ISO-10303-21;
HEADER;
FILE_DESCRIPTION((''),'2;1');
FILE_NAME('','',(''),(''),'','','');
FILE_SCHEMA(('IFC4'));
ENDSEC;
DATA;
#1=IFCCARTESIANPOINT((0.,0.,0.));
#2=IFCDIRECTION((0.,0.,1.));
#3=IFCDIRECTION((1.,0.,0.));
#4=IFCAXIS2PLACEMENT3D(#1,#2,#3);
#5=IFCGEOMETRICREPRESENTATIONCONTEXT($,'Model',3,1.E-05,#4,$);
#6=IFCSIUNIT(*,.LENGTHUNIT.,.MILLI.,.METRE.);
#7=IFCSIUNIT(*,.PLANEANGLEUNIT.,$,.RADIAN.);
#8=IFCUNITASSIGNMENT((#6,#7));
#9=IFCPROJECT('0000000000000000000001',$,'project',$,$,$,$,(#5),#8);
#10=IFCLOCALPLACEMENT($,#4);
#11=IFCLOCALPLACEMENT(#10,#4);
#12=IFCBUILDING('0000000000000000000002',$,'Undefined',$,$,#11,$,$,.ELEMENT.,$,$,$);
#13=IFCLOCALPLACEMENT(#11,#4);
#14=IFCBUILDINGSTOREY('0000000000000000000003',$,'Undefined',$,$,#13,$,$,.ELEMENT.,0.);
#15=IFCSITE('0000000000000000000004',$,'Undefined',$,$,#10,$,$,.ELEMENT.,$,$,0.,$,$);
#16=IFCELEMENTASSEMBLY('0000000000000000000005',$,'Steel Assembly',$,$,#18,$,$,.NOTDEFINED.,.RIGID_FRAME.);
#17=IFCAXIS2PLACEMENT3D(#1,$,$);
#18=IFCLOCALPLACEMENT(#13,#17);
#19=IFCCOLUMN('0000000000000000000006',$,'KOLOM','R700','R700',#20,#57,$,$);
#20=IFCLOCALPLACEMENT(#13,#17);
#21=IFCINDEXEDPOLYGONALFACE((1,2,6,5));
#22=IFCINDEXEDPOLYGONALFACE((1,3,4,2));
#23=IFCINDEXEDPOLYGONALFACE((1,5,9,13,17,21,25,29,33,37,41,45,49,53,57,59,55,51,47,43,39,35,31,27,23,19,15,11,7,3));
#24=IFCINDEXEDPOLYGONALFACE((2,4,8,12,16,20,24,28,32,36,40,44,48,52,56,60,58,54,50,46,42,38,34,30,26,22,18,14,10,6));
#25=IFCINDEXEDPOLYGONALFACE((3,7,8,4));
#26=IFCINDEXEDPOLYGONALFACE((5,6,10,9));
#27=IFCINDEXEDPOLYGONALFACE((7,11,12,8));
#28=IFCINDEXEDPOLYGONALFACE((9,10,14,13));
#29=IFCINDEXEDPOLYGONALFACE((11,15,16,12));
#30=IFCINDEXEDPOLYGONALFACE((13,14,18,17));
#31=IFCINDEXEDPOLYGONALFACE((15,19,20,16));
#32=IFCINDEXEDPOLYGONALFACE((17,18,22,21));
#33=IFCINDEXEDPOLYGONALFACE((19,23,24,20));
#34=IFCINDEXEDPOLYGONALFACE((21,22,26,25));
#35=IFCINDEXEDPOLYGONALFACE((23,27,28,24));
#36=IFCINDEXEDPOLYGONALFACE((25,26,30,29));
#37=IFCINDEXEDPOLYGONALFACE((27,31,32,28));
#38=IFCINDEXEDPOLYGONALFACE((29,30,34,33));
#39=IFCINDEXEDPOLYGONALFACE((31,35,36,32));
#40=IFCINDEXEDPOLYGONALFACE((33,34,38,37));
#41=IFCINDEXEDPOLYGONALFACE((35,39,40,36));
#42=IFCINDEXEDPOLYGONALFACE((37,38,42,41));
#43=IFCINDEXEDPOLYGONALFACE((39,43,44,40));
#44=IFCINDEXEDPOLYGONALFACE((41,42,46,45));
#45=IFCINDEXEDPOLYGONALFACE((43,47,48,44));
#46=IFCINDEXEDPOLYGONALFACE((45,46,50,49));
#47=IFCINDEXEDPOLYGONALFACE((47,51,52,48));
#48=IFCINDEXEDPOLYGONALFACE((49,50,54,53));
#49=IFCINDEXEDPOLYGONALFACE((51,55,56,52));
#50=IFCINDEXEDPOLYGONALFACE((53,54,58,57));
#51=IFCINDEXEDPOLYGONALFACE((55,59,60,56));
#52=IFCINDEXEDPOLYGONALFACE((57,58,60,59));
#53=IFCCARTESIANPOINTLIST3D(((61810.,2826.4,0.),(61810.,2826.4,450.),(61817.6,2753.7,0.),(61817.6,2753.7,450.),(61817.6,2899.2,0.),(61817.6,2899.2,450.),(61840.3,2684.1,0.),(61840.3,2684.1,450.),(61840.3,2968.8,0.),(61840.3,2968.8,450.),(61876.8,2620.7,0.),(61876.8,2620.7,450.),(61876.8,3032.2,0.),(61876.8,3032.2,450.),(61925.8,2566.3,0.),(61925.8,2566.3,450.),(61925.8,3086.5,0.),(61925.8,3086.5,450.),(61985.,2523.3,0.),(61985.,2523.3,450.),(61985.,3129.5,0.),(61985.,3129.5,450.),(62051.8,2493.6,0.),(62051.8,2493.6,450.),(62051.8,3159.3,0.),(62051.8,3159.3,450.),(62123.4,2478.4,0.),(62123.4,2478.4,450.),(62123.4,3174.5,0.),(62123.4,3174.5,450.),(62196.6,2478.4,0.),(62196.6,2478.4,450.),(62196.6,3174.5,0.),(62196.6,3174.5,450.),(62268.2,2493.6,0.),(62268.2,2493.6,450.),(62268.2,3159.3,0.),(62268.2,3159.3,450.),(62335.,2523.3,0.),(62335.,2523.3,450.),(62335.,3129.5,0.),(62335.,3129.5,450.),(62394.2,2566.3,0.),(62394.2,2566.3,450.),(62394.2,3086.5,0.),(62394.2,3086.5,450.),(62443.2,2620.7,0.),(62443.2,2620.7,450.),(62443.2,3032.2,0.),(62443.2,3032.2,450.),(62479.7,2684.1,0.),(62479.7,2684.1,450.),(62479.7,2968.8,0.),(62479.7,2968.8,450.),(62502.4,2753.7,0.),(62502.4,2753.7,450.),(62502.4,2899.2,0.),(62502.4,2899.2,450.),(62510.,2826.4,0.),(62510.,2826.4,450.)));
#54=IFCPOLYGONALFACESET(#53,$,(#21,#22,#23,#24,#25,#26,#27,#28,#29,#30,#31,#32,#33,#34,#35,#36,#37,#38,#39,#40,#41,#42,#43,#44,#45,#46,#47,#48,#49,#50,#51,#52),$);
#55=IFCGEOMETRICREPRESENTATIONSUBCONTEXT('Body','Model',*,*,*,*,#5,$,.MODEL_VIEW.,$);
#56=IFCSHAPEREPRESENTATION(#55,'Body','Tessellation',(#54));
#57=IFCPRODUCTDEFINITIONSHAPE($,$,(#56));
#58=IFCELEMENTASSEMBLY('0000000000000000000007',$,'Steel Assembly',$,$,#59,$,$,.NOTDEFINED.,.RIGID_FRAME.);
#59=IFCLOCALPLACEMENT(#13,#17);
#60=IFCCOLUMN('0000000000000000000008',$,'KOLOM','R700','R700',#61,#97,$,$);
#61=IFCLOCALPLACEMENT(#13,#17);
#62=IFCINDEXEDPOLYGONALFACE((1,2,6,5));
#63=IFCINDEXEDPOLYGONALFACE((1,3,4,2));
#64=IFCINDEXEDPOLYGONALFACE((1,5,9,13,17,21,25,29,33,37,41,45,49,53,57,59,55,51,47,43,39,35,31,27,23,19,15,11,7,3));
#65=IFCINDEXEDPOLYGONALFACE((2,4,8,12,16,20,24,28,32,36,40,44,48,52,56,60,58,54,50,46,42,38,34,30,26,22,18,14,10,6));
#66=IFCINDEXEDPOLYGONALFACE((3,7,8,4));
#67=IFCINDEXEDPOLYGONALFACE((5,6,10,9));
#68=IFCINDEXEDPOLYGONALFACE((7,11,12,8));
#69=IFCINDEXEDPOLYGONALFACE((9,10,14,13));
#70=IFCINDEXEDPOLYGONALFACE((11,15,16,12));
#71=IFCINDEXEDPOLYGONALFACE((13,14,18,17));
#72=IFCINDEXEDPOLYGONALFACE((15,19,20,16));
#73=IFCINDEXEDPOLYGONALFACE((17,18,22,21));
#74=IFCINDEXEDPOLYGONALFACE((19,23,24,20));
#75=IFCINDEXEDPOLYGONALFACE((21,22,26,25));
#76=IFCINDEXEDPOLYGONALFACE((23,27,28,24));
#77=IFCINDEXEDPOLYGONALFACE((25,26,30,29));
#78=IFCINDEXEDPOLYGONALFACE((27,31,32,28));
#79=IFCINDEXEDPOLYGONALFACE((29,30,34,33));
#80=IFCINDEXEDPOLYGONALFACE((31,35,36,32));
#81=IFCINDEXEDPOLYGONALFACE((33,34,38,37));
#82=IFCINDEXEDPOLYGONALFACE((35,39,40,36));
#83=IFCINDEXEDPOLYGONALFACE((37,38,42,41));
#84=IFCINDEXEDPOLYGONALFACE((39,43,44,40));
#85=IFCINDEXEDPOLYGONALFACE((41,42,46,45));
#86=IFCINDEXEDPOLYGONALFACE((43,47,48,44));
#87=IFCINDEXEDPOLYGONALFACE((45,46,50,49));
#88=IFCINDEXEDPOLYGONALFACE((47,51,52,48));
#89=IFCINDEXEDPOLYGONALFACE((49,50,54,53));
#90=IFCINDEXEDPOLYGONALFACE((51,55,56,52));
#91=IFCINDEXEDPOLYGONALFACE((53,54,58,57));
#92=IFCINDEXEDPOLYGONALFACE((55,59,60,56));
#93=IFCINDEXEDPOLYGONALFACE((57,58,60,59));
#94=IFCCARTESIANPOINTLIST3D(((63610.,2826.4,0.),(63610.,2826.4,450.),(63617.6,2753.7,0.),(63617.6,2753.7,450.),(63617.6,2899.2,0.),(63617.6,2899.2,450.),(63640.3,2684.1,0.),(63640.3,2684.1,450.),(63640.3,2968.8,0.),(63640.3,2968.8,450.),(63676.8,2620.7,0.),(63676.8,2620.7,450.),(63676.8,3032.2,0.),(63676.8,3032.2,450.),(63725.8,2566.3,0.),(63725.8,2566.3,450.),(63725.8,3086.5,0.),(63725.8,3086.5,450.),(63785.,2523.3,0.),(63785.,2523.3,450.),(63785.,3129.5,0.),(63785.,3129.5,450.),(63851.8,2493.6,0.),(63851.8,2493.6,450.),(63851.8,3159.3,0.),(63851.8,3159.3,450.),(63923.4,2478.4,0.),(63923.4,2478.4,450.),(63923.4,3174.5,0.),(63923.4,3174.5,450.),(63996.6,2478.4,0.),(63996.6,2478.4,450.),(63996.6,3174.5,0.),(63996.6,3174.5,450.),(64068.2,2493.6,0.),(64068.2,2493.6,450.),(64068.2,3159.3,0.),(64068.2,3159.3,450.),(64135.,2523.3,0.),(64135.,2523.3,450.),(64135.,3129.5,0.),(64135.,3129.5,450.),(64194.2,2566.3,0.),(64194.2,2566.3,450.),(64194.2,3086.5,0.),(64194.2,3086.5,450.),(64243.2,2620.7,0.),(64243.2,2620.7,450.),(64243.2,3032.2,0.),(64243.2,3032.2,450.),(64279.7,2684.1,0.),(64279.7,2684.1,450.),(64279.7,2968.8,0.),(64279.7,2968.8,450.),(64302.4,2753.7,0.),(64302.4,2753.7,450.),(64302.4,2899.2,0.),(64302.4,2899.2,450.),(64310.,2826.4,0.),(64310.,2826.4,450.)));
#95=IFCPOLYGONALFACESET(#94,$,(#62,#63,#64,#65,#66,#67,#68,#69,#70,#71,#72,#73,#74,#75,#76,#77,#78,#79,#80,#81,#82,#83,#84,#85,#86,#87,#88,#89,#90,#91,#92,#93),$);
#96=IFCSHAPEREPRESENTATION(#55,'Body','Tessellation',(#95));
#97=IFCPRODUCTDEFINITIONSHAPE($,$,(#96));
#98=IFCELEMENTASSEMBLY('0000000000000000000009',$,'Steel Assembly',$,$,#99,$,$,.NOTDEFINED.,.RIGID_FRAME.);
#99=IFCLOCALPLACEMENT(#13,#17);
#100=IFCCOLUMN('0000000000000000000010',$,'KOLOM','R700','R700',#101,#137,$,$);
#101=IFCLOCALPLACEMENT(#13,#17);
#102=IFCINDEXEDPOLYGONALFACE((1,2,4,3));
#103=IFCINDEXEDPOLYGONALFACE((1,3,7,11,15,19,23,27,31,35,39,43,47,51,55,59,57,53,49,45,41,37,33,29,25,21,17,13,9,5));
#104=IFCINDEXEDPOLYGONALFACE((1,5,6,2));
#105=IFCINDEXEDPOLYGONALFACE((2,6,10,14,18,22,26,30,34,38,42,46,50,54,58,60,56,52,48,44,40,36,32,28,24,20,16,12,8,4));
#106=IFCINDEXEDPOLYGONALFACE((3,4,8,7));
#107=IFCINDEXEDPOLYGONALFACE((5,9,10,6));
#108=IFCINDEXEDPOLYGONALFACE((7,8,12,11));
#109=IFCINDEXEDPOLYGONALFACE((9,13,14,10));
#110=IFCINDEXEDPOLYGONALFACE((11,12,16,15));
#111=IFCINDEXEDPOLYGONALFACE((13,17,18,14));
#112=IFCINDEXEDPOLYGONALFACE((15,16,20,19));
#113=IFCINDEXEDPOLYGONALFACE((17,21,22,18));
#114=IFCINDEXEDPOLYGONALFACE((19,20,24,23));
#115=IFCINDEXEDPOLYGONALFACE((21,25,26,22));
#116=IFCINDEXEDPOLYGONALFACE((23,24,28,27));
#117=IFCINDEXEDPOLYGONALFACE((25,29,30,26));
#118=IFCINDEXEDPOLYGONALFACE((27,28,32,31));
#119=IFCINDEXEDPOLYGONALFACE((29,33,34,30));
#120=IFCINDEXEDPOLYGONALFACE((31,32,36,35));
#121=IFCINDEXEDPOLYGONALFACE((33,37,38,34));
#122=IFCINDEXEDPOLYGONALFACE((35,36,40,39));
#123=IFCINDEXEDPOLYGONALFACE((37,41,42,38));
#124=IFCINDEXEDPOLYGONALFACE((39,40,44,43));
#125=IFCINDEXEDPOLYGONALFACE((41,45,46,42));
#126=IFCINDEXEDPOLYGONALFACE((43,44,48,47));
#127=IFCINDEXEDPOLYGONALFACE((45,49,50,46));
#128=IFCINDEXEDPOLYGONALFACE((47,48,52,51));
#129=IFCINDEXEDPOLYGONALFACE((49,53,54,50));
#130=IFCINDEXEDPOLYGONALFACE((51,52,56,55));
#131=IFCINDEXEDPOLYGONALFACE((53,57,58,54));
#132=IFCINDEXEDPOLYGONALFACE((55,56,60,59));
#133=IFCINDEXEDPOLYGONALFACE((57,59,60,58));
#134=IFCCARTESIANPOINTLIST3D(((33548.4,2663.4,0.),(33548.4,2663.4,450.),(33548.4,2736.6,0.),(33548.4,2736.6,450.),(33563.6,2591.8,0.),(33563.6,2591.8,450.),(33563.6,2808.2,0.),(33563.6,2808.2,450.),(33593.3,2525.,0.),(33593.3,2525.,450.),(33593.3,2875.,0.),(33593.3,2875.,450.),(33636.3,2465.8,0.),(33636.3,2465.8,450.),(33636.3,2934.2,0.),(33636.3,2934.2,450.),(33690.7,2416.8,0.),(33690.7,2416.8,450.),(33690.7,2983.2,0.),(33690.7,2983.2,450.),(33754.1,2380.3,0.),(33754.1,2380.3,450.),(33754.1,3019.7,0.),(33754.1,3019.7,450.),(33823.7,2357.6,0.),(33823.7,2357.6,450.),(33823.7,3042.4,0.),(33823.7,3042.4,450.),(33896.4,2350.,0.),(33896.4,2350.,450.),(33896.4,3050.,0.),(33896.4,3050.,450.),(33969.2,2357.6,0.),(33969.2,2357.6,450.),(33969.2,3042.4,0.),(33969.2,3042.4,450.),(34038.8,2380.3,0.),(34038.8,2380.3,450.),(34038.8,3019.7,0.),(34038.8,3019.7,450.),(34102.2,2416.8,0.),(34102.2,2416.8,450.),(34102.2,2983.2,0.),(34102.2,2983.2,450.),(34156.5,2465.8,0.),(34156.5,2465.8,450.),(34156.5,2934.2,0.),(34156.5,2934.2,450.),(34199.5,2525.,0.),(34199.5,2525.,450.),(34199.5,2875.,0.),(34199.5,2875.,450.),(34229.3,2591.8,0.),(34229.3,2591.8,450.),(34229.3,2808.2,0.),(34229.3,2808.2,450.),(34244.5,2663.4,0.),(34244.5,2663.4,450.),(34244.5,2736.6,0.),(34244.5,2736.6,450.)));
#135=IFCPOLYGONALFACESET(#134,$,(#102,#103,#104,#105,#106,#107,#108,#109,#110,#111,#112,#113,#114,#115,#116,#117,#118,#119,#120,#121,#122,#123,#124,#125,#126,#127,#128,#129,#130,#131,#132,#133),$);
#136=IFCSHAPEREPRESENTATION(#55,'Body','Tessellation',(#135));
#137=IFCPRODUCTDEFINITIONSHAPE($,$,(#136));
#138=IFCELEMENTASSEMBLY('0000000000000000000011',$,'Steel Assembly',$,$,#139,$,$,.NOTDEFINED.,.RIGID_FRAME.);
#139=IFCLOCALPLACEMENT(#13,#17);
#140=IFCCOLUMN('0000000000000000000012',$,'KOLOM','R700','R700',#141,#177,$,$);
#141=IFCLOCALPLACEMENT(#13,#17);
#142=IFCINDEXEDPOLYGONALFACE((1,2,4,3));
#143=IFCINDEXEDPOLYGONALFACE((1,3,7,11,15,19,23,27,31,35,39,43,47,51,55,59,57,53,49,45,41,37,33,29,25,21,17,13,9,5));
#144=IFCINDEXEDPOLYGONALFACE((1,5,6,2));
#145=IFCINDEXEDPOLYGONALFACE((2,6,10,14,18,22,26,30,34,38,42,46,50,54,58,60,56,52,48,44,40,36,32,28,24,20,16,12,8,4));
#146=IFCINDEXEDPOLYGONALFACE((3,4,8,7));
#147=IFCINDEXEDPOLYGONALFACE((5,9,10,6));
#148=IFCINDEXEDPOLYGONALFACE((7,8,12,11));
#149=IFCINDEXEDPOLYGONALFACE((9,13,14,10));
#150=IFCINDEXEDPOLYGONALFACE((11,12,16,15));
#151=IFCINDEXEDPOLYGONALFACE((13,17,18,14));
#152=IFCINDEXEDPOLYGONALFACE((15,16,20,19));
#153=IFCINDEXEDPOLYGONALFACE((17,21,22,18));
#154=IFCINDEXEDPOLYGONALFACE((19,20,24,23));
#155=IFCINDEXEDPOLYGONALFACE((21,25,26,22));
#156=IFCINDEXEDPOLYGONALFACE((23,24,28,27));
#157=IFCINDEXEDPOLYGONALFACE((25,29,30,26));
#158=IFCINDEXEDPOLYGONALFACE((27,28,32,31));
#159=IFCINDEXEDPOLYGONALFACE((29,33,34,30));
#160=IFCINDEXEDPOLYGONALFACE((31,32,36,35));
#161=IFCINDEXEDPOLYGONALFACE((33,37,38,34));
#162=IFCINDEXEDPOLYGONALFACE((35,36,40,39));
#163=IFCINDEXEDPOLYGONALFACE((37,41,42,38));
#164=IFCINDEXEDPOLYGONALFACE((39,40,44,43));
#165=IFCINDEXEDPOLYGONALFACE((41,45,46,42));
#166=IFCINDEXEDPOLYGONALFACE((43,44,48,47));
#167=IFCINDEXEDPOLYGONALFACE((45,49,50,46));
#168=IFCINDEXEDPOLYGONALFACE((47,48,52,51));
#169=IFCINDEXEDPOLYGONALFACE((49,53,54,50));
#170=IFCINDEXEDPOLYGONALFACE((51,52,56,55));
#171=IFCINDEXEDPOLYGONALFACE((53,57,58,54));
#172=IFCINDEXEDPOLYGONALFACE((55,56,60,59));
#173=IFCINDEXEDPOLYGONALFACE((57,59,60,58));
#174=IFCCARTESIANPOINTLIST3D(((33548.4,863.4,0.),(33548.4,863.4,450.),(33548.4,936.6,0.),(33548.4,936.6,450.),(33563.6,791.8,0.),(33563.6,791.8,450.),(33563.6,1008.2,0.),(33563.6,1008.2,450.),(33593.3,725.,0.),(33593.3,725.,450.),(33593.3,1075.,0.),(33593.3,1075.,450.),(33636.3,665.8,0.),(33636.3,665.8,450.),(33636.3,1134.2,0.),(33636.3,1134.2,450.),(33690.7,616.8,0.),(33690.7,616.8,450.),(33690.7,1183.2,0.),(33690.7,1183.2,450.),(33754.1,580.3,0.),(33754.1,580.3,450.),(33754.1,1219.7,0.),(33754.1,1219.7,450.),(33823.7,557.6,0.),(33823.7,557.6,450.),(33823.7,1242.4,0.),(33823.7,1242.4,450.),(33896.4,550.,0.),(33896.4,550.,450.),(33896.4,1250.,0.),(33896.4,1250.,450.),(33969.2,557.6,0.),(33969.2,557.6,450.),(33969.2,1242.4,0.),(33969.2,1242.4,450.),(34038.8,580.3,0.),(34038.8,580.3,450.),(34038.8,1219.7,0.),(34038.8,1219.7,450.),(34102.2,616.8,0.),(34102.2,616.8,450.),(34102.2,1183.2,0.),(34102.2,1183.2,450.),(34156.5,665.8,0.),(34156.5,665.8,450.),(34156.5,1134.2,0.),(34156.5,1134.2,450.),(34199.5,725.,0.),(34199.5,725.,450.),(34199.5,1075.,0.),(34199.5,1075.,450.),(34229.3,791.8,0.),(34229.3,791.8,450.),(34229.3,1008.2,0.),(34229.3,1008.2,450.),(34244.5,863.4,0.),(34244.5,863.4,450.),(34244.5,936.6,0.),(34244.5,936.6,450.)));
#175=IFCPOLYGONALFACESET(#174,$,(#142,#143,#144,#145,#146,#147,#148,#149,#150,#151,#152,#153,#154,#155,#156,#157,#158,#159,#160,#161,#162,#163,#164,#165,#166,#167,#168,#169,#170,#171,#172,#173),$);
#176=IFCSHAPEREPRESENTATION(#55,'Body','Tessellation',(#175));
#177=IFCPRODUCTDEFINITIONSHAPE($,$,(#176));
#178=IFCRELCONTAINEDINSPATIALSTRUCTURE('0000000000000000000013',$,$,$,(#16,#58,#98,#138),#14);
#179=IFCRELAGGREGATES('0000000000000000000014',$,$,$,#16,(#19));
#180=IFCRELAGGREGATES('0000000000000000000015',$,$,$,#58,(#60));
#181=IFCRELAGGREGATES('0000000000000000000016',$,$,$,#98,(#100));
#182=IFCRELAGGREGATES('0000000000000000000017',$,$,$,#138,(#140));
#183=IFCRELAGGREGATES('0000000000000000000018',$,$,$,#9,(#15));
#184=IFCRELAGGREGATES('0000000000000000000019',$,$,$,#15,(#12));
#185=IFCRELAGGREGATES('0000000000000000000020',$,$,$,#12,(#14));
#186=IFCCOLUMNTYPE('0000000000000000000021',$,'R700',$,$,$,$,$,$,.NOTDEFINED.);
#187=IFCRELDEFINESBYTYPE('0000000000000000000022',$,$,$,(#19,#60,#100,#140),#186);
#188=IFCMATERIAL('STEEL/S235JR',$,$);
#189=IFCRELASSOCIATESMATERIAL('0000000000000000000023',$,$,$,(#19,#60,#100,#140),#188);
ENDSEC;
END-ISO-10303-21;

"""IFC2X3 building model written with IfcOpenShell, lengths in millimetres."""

from ifc_helpers import new_model, si_unit, frame, origin_with_axes, origin_2d_with_axis, place, context, subcontext, project, spatial, circle, extrude, material, type_object, element, aggregate, save


model = new_model("IFC2X3")

# Units and contexts
model_context = context("Model", 3, precision=1e-05, world=origin_with_axes())
body_context = subcontext(model_context, "Body", "Model", "MODEL_VIEW")
ifc_project = project(units=[si_unit("LENGTHUNIT", "METRE", prefix="MILLI"), si_unit("PLANEANGLEUNIT", "RADIAN")], contexts=[model_context])

# Site, building, storey
site_placement = place(None, origin_with_axes())
site = spatial("IfcSite", under=ifc_project, at=site_placement, Name="Undefined", CompositionType="ELEMENT", RefElevation=0.0)
building_placement = place(site_placement, origin_with_axes())
building = spatial("IfcBuilding", under=site, at=building_placement, Name="Undefined", CompositionType="ELEMENT")
storey_placement = place(building_placement, origin_with_axes())
storey = spatial("IfcBuildingStorey", under=building, at=storey_placement, Name="Undefined", CompositionType="ELEMENT", Elevation=0.0)

# Element assemblies, columns
assembly_1_placement = place(storey_placement, origin_with_axes())
assembly_1 = element("IfcElementAssembly", 1, at=assembly_1_placement, inside=storey, Name="Steel Assembly", AssemblyPlace="NOTDEFINED", PredefinedType="RIGID_FRAME")
ifc_material = material(Name="STEEL/S235JR")
column_type = type_object("IfcColumnType", Name="R700", PredefinedType="NOTDEFINED")
column_1_placement = place(assembly_1_placement, frame((62160.0, 2826.4, 450.0), z_axis=(0.0, 0.0, -1.0), x_axis=(0.0, 1.0, 0.0)))
column_1 = element("IfcColumn", 2, at=column_1_placement, type_object=column_type, material=ifc_material, Name="KOLOM", Description="R700", ObjectType="R700", context=body_context, shape_type="SweptSolid", body=[
    extrude(circle(Radius=350.0, at=origin_2d_with_axis()), frame((0.0, 0.0, 450.0), z_axis=(0.0, 0.0, -1.0), x_axis=(0.0, 1.0, 0.0)), (0.0, 0.0, 1.0), 450.0),
])
aggregate(assembly_1, [column_1])
assembly_2_placement = place(storey_placement, origin_with_axes())
assembly_2 = element("IfcElementAssembly", 3, at=assembly_2_placement, inside=storey, Name="Steel Assembly", AssemblyPlace="NOTDEFINED", PredefinedType="RIGID_FRAME")
column_2_placement = place(assembly_2_placement, frame((63960.0, 2826.4, 450.0), z_axis=(0.0, 0.0, -1.0), x_axis=(0.0, 1.0, 0.0)))
column_2 = element("IfcColumn", 4, at=column_2_placement, type_object=column_type, material=ifc_material, Name="KOLOM", Description="R700", ObjectType="R700", context=body_context, shape_type="SweptSolid", body=[
    extrude(circle(Radius=350.0, at=origin_2d_with_axis()), frame((0.0, 0.0, 450.0), z_axis=(0.0, 0.0, -1.0), x_axis=(0.0, 1.0, 0.0)), (0.0, 0.0, 1.0), 450.0),
])
aggregate(assembly_2, [column_2])
assembly_3_placement = place(storey_placement, origin_with_axes())
assembly_3 = element("IfcElementAssembly", 5, at=assembly_3_placement, inside=storey, Name="Steel Assembly", AssemblyPlace="NOTDEFINED", PredefinedType="RIGID_FRAME")
column_3_placement = place(assembly_3_placement, frame((33896.4, 2700.0, 450.0), z_axis=(0.0, 0.0, -1.0), x_axis=(1.0, 0.0, 0.0)))
column_3 = element("IfcColumn", 6, at=column_3_placement, type_object=column_type, material=ifc_material, Name="KOLOM", Description="R700", ObjectType="R700", context=body_context, shape_type="SweptSolid", body=[
    extrude(circle(Radius=350.0, at=origin_2d_with_axis()), frame((0.0, 0.0, 450.0), z_axis=(0.0, 0.0, -1.0), x_axis=(0.0, 1.0, 0.0)), (0.0, 0.0, 1.0), 450.0),
])
aggregate(assembly_3, [column_3])
assembly_4_placement = place(storey_placement, origin_with_axes())
assembly_4 = element("IfcElementAssembly", 7, at=assembly_4_placement, inside=storey, Name="Steel Assembly", AssemblyPlace="NOTDEFINED", PredefinedType="RIGID_FRAME")
column_4_placement = place(assembly_4_placement, frame((33896.4, 900.0, 450.0), z_axis=(0.0, 0.0, -1.0), x_axis=(1.0, 0.0, 0.0)))
column_4 = element("IfcColumn", 8, at=column_4_placement, type_object=column_type, material=ifc_material, Name="KOLOM", Description="R700", ObjectType="R700", context=body_context, shape_type="SweptSolid", body=[
    extrude(circle(Radius=350.0, at=origin_2d_with_axis()), frame((0.0, 0.0, 450.0), z_axis=(0.0, 0.0, -1.0), x_axis=(0.0, 1.0, 0.0)), (0.0, 0.0, 1.0), 450.0),
])
aggregate(assembly_4, [column_4])

save(model, "model.ifc")
